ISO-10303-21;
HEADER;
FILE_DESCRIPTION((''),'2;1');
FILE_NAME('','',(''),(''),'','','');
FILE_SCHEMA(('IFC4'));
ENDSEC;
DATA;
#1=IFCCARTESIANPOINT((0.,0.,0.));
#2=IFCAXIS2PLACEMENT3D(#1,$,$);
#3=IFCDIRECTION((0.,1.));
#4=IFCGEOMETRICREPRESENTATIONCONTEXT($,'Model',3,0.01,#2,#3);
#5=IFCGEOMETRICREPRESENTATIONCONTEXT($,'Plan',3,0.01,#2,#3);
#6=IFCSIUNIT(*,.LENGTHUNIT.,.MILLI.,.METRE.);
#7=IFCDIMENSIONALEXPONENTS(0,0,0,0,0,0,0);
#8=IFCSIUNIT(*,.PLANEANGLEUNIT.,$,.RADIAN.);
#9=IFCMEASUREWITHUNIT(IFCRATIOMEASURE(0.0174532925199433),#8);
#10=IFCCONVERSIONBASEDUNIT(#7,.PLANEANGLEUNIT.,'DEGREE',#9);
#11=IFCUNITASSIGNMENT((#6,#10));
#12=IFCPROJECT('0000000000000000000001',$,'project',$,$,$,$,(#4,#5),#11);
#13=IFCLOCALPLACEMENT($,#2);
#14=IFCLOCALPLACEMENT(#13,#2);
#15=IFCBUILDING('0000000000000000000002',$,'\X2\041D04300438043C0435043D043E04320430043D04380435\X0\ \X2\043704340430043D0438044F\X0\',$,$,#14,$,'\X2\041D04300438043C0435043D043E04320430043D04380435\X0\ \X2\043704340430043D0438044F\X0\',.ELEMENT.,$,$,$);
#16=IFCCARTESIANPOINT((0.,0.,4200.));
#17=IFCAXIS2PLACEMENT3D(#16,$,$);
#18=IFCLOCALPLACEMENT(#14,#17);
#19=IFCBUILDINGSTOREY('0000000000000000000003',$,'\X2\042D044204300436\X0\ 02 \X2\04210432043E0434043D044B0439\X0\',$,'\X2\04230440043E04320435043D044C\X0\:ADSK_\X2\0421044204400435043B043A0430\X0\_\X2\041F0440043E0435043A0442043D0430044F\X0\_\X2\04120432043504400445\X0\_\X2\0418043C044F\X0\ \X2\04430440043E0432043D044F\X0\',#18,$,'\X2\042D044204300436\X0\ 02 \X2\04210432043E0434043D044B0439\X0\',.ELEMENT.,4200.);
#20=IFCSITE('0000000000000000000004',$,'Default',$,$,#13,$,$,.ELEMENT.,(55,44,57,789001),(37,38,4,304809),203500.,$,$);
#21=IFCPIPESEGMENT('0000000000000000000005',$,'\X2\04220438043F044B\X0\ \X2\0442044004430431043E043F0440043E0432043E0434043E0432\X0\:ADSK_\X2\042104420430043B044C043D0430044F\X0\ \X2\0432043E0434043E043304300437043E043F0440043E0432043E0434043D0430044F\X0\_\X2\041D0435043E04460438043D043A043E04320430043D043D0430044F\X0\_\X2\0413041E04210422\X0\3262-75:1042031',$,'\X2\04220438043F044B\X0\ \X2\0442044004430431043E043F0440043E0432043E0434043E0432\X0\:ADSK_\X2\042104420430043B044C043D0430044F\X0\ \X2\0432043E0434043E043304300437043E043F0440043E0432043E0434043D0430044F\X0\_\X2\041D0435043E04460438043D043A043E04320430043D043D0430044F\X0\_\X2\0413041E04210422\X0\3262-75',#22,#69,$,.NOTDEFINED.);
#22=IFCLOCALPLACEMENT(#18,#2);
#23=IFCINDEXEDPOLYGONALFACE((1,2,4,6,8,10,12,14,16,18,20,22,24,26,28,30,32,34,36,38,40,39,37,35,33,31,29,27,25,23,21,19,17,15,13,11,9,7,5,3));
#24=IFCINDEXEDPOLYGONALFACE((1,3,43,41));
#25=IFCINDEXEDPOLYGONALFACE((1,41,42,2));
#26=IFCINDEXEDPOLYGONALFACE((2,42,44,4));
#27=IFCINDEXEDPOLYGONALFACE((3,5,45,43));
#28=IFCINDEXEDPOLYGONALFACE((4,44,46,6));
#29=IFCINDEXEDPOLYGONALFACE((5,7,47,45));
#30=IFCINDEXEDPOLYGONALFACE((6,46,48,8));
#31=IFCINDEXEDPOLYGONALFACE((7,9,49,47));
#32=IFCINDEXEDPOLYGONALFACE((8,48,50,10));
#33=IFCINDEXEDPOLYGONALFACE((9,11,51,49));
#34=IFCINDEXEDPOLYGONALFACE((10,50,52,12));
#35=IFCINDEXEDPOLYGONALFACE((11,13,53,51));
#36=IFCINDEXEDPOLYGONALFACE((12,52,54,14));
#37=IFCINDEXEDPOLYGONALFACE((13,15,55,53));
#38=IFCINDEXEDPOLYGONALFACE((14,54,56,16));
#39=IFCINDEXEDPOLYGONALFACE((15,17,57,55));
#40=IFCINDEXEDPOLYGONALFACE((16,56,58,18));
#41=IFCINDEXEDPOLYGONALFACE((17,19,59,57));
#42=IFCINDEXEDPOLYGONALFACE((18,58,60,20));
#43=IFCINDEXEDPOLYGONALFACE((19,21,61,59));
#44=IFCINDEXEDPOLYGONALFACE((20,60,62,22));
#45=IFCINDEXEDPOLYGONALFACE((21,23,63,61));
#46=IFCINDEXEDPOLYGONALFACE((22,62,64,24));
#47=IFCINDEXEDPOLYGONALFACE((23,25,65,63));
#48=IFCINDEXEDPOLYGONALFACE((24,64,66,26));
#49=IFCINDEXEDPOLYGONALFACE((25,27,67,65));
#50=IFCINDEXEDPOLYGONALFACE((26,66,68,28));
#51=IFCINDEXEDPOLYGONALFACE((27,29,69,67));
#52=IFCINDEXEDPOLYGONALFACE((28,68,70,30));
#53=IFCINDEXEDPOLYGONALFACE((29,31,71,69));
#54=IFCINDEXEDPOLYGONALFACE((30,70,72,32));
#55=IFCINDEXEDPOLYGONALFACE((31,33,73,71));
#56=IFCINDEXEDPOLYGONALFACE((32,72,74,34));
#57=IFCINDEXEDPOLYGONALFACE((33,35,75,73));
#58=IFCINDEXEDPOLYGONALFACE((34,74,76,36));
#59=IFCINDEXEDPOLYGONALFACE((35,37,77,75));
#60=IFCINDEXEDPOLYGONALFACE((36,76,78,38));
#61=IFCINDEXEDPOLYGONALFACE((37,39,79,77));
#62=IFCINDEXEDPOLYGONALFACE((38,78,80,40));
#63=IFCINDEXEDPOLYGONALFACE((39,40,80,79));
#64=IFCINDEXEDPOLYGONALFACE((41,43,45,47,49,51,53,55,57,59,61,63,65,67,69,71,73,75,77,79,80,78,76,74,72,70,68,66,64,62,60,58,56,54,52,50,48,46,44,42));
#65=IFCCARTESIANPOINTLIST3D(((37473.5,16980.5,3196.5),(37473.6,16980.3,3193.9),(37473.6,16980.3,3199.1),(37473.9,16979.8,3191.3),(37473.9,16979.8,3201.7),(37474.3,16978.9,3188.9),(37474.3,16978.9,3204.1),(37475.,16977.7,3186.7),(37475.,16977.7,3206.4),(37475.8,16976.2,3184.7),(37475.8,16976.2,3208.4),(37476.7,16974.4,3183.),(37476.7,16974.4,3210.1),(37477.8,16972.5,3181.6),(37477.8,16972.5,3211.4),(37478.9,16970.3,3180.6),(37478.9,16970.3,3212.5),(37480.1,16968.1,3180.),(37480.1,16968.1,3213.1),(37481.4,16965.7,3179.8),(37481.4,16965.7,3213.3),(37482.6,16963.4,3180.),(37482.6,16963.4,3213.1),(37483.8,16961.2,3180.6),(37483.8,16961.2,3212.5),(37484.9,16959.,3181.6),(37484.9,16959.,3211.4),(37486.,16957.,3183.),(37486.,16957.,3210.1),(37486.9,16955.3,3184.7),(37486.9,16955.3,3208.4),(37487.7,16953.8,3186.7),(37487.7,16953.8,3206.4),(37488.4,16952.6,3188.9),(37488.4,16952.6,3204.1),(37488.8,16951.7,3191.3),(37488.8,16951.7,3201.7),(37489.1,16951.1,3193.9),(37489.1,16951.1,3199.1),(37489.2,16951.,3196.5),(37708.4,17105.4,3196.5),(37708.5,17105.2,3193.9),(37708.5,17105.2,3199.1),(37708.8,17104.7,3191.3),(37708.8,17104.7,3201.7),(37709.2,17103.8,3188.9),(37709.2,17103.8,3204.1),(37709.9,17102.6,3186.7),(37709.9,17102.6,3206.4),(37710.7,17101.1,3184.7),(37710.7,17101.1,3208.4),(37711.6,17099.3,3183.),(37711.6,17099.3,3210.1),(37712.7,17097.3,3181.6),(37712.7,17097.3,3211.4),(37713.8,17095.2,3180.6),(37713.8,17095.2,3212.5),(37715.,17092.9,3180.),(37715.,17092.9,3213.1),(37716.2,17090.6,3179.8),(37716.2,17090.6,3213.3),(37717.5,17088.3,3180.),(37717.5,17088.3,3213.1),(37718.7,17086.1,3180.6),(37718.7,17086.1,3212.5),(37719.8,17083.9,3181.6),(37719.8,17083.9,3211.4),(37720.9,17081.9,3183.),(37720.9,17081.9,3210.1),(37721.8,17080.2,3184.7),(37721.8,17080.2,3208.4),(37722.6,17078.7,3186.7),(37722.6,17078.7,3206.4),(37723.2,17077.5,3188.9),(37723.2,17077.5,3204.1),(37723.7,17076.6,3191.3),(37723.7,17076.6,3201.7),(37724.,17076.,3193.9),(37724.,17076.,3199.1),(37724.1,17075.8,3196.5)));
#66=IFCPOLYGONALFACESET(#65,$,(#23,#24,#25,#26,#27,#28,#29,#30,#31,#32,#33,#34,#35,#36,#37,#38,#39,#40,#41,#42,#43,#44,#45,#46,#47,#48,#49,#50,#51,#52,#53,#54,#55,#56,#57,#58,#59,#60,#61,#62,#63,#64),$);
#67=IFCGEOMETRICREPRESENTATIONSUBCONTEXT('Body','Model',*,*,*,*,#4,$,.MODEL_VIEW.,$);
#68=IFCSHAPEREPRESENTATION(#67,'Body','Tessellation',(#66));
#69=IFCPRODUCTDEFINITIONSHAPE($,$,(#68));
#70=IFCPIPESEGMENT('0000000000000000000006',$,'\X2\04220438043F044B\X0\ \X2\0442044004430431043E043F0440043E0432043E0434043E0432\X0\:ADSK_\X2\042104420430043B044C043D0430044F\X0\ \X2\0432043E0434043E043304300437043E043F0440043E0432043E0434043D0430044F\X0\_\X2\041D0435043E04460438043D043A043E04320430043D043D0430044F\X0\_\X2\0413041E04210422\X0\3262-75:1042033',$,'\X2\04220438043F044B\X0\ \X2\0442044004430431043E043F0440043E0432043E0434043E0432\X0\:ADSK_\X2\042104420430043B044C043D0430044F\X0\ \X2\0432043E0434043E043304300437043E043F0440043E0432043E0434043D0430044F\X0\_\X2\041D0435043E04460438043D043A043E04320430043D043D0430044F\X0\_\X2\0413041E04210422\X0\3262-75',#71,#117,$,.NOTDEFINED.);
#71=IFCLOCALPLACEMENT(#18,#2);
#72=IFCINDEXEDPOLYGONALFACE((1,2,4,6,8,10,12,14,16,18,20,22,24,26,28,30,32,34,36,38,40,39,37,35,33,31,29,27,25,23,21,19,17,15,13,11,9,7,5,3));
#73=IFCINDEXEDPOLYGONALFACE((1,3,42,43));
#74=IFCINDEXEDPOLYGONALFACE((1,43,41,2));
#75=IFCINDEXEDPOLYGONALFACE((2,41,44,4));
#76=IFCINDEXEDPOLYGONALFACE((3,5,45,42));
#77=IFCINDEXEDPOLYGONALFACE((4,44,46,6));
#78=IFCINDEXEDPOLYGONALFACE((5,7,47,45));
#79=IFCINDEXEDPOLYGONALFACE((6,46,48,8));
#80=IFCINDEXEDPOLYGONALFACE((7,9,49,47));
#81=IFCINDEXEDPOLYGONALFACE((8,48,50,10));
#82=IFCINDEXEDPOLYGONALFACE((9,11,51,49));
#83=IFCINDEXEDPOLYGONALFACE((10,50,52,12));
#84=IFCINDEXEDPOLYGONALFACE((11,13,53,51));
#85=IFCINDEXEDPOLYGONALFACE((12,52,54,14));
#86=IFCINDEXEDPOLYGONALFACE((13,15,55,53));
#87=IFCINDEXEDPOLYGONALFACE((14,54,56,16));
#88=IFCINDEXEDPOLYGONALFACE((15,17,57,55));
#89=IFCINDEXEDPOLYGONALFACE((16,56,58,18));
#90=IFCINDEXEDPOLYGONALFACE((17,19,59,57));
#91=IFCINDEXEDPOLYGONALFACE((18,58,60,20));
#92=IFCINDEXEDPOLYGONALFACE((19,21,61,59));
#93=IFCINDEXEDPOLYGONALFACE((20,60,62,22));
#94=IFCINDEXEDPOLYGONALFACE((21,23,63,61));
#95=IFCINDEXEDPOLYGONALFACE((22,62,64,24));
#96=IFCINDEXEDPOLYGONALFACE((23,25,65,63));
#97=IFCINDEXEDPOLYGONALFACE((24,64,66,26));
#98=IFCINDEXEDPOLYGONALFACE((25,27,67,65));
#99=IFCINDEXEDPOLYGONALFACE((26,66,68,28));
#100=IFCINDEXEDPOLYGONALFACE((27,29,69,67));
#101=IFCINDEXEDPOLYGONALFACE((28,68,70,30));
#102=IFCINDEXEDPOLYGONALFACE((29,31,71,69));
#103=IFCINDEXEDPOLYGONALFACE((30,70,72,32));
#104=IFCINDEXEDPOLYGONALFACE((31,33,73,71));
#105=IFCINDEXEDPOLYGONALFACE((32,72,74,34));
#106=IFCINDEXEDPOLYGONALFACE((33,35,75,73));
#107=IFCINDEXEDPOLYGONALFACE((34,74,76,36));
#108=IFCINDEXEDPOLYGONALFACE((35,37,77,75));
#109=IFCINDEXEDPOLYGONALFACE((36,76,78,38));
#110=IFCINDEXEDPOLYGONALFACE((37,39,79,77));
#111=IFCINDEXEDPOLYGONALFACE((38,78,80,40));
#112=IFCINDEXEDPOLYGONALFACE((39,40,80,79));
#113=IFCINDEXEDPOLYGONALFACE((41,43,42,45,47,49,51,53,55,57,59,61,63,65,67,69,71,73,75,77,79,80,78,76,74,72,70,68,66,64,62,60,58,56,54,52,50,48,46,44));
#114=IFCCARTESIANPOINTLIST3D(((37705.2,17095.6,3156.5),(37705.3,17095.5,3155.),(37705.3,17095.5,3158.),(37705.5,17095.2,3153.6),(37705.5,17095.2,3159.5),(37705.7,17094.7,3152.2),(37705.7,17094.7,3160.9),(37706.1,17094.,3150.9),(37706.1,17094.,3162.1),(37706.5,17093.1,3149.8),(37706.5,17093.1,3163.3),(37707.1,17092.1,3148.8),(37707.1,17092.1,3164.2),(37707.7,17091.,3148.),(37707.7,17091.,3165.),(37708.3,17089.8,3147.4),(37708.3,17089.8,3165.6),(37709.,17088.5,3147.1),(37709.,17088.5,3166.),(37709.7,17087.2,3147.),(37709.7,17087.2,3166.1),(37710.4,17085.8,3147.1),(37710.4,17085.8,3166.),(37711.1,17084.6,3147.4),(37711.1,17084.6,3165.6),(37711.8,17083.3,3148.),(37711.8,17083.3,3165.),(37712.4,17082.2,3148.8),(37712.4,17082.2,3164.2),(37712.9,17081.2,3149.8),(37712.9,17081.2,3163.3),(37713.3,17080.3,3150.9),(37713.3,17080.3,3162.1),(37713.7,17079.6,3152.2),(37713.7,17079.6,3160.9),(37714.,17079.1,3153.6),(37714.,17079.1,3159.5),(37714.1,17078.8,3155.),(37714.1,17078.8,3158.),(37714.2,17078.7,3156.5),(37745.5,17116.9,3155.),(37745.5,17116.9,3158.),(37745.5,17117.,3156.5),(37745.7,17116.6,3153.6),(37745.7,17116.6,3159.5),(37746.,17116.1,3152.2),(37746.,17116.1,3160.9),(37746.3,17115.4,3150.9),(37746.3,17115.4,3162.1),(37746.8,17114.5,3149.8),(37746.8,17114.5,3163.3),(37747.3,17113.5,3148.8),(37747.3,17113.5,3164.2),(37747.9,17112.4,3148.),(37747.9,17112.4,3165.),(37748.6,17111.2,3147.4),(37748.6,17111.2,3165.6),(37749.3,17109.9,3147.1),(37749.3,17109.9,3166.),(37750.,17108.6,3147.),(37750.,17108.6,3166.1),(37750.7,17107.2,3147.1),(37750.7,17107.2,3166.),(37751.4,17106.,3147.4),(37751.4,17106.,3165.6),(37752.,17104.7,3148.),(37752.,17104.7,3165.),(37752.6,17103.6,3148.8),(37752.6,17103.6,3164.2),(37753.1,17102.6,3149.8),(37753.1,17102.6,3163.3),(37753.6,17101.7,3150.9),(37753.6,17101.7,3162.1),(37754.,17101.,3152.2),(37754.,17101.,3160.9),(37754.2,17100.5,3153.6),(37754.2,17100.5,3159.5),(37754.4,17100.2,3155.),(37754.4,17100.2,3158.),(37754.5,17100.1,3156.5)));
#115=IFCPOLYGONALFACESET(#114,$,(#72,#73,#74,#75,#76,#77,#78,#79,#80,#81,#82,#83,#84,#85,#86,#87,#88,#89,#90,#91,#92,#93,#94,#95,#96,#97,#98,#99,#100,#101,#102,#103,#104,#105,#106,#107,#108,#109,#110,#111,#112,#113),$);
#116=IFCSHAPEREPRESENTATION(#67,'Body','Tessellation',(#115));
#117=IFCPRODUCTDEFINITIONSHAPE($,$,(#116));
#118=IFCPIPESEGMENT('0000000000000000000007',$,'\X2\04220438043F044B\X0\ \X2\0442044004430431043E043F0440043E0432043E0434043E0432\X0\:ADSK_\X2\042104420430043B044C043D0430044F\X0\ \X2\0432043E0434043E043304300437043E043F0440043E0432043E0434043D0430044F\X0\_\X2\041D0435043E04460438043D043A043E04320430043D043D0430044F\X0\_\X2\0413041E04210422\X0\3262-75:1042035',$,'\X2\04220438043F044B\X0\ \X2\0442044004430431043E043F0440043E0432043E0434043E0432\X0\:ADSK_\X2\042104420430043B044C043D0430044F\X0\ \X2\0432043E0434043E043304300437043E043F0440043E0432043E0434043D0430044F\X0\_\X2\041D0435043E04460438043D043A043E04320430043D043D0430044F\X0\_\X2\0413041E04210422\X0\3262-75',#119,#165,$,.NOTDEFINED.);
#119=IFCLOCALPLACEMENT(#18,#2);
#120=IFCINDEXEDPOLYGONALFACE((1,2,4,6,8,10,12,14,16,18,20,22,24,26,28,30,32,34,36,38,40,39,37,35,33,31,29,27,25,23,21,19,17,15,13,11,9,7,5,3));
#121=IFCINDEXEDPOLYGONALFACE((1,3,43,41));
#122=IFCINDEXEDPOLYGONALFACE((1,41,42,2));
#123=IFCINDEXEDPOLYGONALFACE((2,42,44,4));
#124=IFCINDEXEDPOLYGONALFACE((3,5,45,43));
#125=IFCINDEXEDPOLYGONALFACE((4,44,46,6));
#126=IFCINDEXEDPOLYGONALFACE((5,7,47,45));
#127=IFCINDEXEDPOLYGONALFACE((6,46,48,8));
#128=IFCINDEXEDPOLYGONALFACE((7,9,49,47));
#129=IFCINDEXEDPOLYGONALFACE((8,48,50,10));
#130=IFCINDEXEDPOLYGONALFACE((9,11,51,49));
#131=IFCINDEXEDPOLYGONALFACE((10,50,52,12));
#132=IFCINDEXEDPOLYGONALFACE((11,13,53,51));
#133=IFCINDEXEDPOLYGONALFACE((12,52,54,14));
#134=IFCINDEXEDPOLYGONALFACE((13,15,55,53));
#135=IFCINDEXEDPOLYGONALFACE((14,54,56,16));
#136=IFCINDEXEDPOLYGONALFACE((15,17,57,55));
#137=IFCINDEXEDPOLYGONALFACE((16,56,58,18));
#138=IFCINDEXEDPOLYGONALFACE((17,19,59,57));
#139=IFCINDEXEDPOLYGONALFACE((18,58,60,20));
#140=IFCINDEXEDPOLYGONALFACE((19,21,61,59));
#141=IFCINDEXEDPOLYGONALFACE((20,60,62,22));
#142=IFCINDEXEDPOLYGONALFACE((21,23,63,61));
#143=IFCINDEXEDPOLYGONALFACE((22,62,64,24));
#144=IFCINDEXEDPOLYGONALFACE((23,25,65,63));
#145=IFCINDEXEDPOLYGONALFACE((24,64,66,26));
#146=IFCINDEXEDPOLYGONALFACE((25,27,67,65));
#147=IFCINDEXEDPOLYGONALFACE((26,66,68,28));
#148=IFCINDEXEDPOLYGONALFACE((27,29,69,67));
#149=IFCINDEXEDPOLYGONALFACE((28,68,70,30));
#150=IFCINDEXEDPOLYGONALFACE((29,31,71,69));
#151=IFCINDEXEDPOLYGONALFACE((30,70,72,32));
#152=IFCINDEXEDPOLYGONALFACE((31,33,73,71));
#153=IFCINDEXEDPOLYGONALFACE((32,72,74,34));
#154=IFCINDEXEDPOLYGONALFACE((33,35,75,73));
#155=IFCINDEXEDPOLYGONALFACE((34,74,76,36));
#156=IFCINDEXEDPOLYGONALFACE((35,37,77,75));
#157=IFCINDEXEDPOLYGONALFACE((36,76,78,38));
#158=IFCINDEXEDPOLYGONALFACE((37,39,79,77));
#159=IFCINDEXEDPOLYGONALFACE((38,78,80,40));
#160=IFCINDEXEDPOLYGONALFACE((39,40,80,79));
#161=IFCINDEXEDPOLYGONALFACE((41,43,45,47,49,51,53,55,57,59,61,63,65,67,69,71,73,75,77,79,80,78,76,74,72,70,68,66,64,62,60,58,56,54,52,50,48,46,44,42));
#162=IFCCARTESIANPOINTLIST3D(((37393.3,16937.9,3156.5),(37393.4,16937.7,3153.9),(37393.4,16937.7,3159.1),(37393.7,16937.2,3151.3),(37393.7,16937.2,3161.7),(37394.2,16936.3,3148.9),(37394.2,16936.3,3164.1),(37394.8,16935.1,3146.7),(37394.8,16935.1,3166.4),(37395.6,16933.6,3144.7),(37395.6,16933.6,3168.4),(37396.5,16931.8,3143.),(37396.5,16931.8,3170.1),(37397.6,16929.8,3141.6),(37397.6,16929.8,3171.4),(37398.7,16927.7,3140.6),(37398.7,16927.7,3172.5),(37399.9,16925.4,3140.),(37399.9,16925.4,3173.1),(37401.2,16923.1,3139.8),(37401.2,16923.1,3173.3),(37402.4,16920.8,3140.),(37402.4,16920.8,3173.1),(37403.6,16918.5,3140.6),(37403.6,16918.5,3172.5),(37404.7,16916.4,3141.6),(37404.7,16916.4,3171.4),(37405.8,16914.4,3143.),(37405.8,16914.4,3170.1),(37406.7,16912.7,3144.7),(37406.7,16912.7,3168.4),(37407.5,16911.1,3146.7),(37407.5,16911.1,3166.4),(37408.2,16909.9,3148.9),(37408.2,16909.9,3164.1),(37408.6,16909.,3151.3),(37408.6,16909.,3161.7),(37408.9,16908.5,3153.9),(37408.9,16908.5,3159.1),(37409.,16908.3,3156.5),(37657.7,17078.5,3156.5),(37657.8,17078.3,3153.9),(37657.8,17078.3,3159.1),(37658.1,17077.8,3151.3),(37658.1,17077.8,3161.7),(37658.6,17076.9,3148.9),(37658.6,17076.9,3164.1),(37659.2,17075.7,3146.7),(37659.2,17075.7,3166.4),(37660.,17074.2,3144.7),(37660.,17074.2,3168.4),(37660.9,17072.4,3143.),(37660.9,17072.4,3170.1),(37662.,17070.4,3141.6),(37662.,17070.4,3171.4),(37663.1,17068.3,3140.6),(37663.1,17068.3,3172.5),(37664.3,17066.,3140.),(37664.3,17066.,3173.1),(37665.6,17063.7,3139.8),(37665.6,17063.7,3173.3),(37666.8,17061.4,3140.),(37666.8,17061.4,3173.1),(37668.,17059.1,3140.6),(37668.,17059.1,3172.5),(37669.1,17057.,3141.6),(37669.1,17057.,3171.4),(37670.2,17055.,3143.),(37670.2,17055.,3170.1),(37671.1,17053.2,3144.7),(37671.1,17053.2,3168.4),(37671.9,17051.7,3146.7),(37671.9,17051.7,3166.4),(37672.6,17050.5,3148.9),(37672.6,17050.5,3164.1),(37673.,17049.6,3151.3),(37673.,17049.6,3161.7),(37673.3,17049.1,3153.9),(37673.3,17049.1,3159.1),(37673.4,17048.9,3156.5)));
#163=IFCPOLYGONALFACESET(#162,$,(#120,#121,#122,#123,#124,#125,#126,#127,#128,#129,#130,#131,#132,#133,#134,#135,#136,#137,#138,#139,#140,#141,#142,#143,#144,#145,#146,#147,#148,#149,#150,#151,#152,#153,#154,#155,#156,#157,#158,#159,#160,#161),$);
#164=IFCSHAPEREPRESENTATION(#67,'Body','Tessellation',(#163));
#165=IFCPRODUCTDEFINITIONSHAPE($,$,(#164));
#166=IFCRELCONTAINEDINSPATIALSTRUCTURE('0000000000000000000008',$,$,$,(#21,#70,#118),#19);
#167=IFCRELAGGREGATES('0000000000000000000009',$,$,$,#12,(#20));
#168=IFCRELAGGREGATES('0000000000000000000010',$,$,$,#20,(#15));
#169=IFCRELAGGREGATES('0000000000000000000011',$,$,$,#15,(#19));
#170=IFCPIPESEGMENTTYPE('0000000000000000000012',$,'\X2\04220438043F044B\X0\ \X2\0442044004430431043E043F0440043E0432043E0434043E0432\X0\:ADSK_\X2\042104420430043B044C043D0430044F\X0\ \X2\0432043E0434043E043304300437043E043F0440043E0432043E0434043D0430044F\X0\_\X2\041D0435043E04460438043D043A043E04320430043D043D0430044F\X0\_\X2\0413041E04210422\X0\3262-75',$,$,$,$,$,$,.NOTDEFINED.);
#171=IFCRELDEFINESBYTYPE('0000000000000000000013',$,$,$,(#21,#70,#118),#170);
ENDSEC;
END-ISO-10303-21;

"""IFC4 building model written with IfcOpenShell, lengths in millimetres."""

from ifc_helpers import new_model, entity, si_unit, converted_unit, direction, frame, origin, place, context, subcontext, project, spatial, indexed_curve, outline, extrude, type_object, element, save


model = new_model("IFC4")

# Units and contexts
model_context = context("Model", 3, precision=0.01, world=origin(), true_north=direction((0.0, 1.0)))
plan_context = context("Plan", 3, precision=0.01, world=origin(), true_north=direction((0.0, 1.0)))
body_context = subcontext(model_context, "Body", "Model", "MODEL_VIEW")
ifc_project = project(units=[si_unit("LENGTHUNIT", "METRE", prefix="MILLI"), converted_unit("PLANEANGLEUNIT", "DEGREE", entity("IfcRatioMeasure", 0.0174532925199433), si_unit("PLANEANGLEUNIT", "RADIAN"), dimensions=[0, 0, 0, 0, 0, 0, 0])], contexts=[model_context, plan_context])

# Site, building, storey
site_placement = place(None, origin())
site = spatial("IfcSite", under=ifc_project, at=site_placement, Name="Default", CompositionType="ELEMENT", RefLatitude=(55, 44, 57, 789001), RefLongitude=(37, 38, 4, 304809), RefElevation=203500.0)
building_placement = place(site_placement, origin())
building = spatial("IfcBuilding", under=site, at=building_placement, Name="Наименование здания", LongName="Наименование здания", CompositionType="ELEMENT")
storey_placement = place(building_placement, frame((0.0, 0.0, 4200.0)))
storey = spatial("IfcBuildingStorey", under=building, at=storey_placement, Name="Этаж 02 Сводный", ObjectType="Уровень:ADSK_Стрелка_Проектная_Вверх_Имя уровня", LongName="Этаж 02 Сводный", CompositionType="ELEMENT", Elevation=4200.0)

# Pipe segments
pipe_segment_type = type_object("IfcPipeSegmentType", Name="Типы трубопроводов:ADSK_Стальная водогазопроводная_Неоцинкованная_ГОСТ3262-75", PredefinedType="NOTDEFINED")
placement = place(storey_placement, origin())
element("IfcPipeSegment", 1, at=placement, inside=storey, type_object=pipe_segment_type, Name="Типы трубопроводов:ADSK_Стальная водогазопроводная_Неоцинкованная_ГОСТ3262-75:1042031", ObjectType="Типы трубопроводов:ADSK_Стальная водогазопроводная_Неоцинкованная_ГОСТ3262-75", PredefinedType="NOTDEFINED", context=body_context, shape_type="SweptSolid", body=[
    extrude(outline(indexed_curve([(16.7, 0.0), (16.5, 2.6), (15.9, 5.2), (14.9, 7.6), (13.6, 9.8), (11.8, 11.8), (9.8, 13.6), (7.6, 14.9), (5.2, 15.9), (2.6, 16.5), (0.0, 16.8), (-2.6, 16.5), (-5.2, 15.9), (-7.6, 14.9), (-9.8, 13.6), (-11.8, 11.8), (-13.6, 9.8), (-14.9, 7.6), (-15.9, 5.2), (-16.5, 2.6), (-16.7, 0.0), (-16.5, -2.6), (-15.9, -5.2), (-14.9, -7.6), (-13.6, -9.8), (-11.8, -11.8), (-9.8, -13.6), (-7.6, -14.9), (-5.2, -15.9), (-2.6, -16.5), (0.0, -16.8), (2.6, -16.5), (5.2, -15.9), (7.6, -14.9), (9.8, -13.6), (11.8, -11.8), (13.6, -9.8), (14.9, -7.6), (15.9, -5.2), (16.5, -2.6), (16.7, 0.0)], self_intersect=False)), frame((37481.3, 16965.7, 3196.5), z_axis=(0.882948, 0.469472, 0.0), x_axis=(-0.469472, 0.882948, 0.0)), (0.0, 0.0, 1.0), 266.0),
])
element("IfcPipeSegment", 2, at=placement, inside=storey, type_object=pipe_segment_type, Name="Типы трубопроводов:ADSK_Стальная водогазопроводная_Неоцинкованная_ГОСТ3262-75:1042033", ObjectType="Типы трубопроводов:ADSK_Стальная водогазопроводная_Неоцинкованная_ГОСТ3262-75", PredefinedType="NOTDEFINED", context=body_context, shape_type="SweptSolid", body=[
    extrude(outline(indexed_curve([(9.6, 0.0), (9.4, 1.5), (9.1, 3.0), (8.5, 4.3), (7.7, 5.6), (6.8, 6.8), (5.6, 7.7), (4.3, 8.5), (3.0, 9.1), (1.5, 9.4), (0.0, 9.6), (-1.5, 9.4), (-3.0, 9.1), (-4.3, 8.5), (-5.6, 7.7), (-6.8, 6.8), (-7.7, 5.6), (-8.5, 4.3), (-9.1, 3.0), (-9.4, 1.5), (-9.6, 0.0), (-9.4, -1.5), (-9.1, -3.0), (-8.5, -4.3), (-7.7, -5.6), (-6.8, -6.8), (-5.6, -7.7), (-4.3, -8.5), (-3.0, -9.1), (-1.5, -9.4), (0.0, -9.6), (1.5, -9.4), (3.0, -9.1), (4.3, -8.5), (5.6, -7.7), (6.8, -6.8), (7.7, -5.6), (8.5, -4.3), (9.1, -3.0), (9.4, -1.5), (9.6, 0.0)], self_intersect=False)), frame((37709.7, 17087.2, 3156.5), z_axis=(0.882948, 0.469472, 0.0), x_axis=(-0.469472, 0.882948, 0.0)), (0.0, 0.0, 1.0), 45.6),
])
element("IfcPipeSegment", 3, at=placement, inside=storey, type_object=pipe_segment_type, Name="Типы трубопроводов:ADSK_Стальная водогазопроводная_Неоцинкованная_ГОСТ3262-75:1042035", ObjectType="Типы трубопроводов:ADSK_Стальная водогазопроводная_Неоцинкованная_ГОСТ3262-75", PredefinedType="NOTDEFINED", context=body_context, shape_type="SweptSolid", body=[
    extrude(outline(indexed_curve([(16.7, 0.0), (16.5, 2.6), (15.9, 5.2), (14.9, 7.6), (13.6, 9.8), (11.8, 11.8), (9.8, 13.6), (7.6, 14.9), (5.2, 15.9), (2.6, 16.5), (0.0, 16.8), (-2.6, 16.5), (-5.2, 15.9), (-7.6, 14.9), (-9.8, 13.6), (-11.8, 11.8), (-13.6, 9.8), (-14.9, 7.6), (-15.9, 5.2), (-16.5, 2.6), (-16.7, 0.0), (-16.5, -2.6), (-15.9, -5.2), (-14.9, -7.6), (-13.6, -9.8), (-11.8, -11.8), (-9.8, -13.6), (-7.6, -14.9), (-5.2, -15.9), (-2.6, -16.5), (0.0, -16.8), (2.6, -16.5), (5.2, -15.9), (7.6, -14.9), (9.8, -13.6), (11.8, -11.8), (13.6, -9.8), (14.9, -7.6), (15.9, -5.2), (16.5, -2.6), (16.7, 0.0)], self_intersect=False)), frame((37401.2, 16923.1, 3156.5), z_axis=(0.882948, 0.469472, 0.0), x_axis=(-0.469472, 0.882948, 0.0)), (0.0, 0.0, 1.0), 299.5),
])

save(model, "model.ifc")
